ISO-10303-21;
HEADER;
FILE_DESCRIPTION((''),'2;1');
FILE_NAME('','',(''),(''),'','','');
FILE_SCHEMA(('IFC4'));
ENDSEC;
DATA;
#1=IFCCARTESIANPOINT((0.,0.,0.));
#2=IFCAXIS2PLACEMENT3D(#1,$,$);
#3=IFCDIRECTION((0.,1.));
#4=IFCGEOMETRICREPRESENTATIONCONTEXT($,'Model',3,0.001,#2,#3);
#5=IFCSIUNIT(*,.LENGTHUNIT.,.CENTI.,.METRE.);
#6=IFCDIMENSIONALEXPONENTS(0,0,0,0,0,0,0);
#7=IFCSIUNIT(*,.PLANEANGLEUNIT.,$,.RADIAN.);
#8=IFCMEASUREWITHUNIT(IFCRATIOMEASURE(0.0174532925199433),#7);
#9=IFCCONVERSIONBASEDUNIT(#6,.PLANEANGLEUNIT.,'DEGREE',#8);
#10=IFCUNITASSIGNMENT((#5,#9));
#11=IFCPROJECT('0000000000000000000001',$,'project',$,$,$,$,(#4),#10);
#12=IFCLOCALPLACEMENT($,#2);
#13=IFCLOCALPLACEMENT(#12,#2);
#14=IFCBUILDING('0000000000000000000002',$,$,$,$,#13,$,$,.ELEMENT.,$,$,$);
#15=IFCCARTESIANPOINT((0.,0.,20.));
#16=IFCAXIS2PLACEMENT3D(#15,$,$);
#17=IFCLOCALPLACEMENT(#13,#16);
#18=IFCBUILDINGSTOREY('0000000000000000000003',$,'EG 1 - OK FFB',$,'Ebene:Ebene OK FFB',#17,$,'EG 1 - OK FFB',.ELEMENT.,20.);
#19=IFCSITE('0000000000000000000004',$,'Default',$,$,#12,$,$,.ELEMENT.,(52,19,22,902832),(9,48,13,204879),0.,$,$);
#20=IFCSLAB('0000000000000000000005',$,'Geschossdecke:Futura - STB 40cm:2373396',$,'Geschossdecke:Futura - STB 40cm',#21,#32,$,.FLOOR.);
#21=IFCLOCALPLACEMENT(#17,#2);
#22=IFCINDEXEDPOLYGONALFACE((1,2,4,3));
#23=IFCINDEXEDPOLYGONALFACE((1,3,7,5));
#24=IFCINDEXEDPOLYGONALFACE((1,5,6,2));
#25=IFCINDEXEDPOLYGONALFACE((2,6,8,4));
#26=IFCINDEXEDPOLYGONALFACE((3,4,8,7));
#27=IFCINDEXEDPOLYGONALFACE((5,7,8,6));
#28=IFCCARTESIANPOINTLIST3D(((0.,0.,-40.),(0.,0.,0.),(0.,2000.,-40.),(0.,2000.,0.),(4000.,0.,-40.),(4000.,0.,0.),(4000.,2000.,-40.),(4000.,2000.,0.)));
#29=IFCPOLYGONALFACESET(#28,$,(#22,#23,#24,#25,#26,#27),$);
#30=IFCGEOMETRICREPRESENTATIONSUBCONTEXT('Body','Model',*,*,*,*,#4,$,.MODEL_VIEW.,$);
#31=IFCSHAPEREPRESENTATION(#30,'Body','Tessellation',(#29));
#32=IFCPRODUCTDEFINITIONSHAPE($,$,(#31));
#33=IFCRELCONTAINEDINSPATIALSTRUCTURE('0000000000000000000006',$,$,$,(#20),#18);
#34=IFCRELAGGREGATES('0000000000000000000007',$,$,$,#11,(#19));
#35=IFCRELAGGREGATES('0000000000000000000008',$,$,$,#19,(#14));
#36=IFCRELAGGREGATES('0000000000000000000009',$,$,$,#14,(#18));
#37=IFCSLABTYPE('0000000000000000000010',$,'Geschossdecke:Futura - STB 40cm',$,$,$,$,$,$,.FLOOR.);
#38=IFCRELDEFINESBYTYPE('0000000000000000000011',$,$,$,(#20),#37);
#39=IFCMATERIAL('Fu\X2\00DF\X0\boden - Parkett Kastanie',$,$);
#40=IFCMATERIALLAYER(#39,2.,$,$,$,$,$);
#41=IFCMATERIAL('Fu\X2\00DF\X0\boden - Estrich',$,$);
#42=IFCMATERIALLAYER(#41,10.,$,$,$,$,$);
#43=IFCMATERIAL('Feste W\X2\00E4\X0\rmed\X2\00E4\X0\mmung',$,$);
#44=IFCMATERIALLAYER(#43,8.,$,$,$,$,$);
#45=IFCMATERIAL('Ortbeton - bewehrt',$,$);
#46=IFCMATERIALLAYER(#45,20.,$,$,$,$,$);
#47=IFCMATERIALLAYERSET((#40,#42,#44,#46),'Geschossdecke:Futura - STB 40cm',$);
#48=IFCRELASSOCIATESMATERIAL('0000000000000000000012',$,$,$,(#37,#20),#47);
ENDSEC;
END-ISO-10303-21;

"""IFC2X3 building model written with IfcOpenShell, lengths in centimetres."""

from ifc_helpers import new_model, entity, si_unit, converted_unit, direction, frame, origin, origin_2d_with_axis, place, context, subcontext, project, spatial, rectangle, extrude, material, layer, layer_set, layer_usage, type_object, element, save


model = new_model("IFC2X3")

# Units and contexts
model_context = context("Model", 3, precision=0.001, world=origin(), true_north=direction((0.0, 1.0)))
body_context = subcontext(model_context, "Body", "Model", "MODEL_VIEW")
ifc_project = project(units=[si_unit("LENGTHUNIT", "METRE", prefix="CENTI"), converted_unit("PLANEANGLEUNIT", "DEGREE", entity("IfcRatioMeasure", 0.0174532925199433), si_unit("PLANEANGLEUNIT", "RADIAN"), dimensions=[0, 0, 0, 0, 0, 0, 0])], contexts=[model_context])

# Site, building, storey
site_placement = place(None, frame((0.0, 0.0, 0.0)))
site = spatial("IfcSite", under=ifc_project, at=site_placement, Name="Default", CompositionType="ELEMENT", RefLatitude=(52, 19, 22, 902832), RefLongitude=(9, 48, 13, 204879), RefElevation=0.0)
building_placement = place(site_placement, origin())
building = spatial("IfcBuilding", under=site, at=building_placement, CompositionType="ELEMENT")
storey_placement = place(building_placement, frame((0.0, 0.0, 20.0)))
storey = spatial("IfcBuildingStorey", under=building, at=storey_placement, Name="EG 1 - OK FFB", ObjectType="Ebene:Ebene OK FFB", LongName="EG 1 - OK FFB", CompositionType="ELEMENT", Elevation=20.0)

# Slab
ifc_material_1 = material(Name="Fußboden - Parkett Kastanie")
ifc_layer_1 = layer(ifc_material_1, 2.0)
ifc_material_2 = material(Name="Fußboden - Estrich")
ifc_layer_2 = layer(ifc_material_2, 10.0)
ifc_material_3 = material(Name="Feste Wärmedämmung")
ifc_layer_3 = layer(ifc_material_3, 8.0)
ifc_material_4 = material(Name="Ortbeton - bewehrt")
ifc_layer_4 = layer(ifc_material_4, 20.0)
ifc_layer_set = layer_set([ifc_layer_1, ifc_layer_2, ifc_layer_3, ifc_layer_4], Name="Geschossdecke:Futura - STB 40cm")
ifc_layer_usage = layer_usage(ifc_layer_set, "AXIS3", "POSITIVE", 0.0)
slab_type = type_object("IfcSlabType", Name="Geschossdecke:Futura - STB 40cm", PredefinedType="FLOOR", material=ifc_layer_set)
slab_placement = place(storey_placement, origin())
element("IfcSlab", 1, at=slab_placement, inside=storey, type_object=slab_type, material=ifc_layer_usage, Name="Geschossdecke:Futura - STB 40cm:2373396", ObjectType="Geschossdecke:Futura - STB 40cm", PredefinedType="FLOOR", context=body_context, shape_type="SweptSolid", body=[
    extrude(rectangle(XDim=2000.0, YDim=4000.0, at=origin_2d_with_axis()), frame((2000.0, 1000.0, 0.0), z_axis=(0.0, 0.0, -1.0), x_axis=(0.0, 1.0, 0.0)), (0.0, 0.0, 1.0), 40.0),
])

save(model, "model.ifc")
